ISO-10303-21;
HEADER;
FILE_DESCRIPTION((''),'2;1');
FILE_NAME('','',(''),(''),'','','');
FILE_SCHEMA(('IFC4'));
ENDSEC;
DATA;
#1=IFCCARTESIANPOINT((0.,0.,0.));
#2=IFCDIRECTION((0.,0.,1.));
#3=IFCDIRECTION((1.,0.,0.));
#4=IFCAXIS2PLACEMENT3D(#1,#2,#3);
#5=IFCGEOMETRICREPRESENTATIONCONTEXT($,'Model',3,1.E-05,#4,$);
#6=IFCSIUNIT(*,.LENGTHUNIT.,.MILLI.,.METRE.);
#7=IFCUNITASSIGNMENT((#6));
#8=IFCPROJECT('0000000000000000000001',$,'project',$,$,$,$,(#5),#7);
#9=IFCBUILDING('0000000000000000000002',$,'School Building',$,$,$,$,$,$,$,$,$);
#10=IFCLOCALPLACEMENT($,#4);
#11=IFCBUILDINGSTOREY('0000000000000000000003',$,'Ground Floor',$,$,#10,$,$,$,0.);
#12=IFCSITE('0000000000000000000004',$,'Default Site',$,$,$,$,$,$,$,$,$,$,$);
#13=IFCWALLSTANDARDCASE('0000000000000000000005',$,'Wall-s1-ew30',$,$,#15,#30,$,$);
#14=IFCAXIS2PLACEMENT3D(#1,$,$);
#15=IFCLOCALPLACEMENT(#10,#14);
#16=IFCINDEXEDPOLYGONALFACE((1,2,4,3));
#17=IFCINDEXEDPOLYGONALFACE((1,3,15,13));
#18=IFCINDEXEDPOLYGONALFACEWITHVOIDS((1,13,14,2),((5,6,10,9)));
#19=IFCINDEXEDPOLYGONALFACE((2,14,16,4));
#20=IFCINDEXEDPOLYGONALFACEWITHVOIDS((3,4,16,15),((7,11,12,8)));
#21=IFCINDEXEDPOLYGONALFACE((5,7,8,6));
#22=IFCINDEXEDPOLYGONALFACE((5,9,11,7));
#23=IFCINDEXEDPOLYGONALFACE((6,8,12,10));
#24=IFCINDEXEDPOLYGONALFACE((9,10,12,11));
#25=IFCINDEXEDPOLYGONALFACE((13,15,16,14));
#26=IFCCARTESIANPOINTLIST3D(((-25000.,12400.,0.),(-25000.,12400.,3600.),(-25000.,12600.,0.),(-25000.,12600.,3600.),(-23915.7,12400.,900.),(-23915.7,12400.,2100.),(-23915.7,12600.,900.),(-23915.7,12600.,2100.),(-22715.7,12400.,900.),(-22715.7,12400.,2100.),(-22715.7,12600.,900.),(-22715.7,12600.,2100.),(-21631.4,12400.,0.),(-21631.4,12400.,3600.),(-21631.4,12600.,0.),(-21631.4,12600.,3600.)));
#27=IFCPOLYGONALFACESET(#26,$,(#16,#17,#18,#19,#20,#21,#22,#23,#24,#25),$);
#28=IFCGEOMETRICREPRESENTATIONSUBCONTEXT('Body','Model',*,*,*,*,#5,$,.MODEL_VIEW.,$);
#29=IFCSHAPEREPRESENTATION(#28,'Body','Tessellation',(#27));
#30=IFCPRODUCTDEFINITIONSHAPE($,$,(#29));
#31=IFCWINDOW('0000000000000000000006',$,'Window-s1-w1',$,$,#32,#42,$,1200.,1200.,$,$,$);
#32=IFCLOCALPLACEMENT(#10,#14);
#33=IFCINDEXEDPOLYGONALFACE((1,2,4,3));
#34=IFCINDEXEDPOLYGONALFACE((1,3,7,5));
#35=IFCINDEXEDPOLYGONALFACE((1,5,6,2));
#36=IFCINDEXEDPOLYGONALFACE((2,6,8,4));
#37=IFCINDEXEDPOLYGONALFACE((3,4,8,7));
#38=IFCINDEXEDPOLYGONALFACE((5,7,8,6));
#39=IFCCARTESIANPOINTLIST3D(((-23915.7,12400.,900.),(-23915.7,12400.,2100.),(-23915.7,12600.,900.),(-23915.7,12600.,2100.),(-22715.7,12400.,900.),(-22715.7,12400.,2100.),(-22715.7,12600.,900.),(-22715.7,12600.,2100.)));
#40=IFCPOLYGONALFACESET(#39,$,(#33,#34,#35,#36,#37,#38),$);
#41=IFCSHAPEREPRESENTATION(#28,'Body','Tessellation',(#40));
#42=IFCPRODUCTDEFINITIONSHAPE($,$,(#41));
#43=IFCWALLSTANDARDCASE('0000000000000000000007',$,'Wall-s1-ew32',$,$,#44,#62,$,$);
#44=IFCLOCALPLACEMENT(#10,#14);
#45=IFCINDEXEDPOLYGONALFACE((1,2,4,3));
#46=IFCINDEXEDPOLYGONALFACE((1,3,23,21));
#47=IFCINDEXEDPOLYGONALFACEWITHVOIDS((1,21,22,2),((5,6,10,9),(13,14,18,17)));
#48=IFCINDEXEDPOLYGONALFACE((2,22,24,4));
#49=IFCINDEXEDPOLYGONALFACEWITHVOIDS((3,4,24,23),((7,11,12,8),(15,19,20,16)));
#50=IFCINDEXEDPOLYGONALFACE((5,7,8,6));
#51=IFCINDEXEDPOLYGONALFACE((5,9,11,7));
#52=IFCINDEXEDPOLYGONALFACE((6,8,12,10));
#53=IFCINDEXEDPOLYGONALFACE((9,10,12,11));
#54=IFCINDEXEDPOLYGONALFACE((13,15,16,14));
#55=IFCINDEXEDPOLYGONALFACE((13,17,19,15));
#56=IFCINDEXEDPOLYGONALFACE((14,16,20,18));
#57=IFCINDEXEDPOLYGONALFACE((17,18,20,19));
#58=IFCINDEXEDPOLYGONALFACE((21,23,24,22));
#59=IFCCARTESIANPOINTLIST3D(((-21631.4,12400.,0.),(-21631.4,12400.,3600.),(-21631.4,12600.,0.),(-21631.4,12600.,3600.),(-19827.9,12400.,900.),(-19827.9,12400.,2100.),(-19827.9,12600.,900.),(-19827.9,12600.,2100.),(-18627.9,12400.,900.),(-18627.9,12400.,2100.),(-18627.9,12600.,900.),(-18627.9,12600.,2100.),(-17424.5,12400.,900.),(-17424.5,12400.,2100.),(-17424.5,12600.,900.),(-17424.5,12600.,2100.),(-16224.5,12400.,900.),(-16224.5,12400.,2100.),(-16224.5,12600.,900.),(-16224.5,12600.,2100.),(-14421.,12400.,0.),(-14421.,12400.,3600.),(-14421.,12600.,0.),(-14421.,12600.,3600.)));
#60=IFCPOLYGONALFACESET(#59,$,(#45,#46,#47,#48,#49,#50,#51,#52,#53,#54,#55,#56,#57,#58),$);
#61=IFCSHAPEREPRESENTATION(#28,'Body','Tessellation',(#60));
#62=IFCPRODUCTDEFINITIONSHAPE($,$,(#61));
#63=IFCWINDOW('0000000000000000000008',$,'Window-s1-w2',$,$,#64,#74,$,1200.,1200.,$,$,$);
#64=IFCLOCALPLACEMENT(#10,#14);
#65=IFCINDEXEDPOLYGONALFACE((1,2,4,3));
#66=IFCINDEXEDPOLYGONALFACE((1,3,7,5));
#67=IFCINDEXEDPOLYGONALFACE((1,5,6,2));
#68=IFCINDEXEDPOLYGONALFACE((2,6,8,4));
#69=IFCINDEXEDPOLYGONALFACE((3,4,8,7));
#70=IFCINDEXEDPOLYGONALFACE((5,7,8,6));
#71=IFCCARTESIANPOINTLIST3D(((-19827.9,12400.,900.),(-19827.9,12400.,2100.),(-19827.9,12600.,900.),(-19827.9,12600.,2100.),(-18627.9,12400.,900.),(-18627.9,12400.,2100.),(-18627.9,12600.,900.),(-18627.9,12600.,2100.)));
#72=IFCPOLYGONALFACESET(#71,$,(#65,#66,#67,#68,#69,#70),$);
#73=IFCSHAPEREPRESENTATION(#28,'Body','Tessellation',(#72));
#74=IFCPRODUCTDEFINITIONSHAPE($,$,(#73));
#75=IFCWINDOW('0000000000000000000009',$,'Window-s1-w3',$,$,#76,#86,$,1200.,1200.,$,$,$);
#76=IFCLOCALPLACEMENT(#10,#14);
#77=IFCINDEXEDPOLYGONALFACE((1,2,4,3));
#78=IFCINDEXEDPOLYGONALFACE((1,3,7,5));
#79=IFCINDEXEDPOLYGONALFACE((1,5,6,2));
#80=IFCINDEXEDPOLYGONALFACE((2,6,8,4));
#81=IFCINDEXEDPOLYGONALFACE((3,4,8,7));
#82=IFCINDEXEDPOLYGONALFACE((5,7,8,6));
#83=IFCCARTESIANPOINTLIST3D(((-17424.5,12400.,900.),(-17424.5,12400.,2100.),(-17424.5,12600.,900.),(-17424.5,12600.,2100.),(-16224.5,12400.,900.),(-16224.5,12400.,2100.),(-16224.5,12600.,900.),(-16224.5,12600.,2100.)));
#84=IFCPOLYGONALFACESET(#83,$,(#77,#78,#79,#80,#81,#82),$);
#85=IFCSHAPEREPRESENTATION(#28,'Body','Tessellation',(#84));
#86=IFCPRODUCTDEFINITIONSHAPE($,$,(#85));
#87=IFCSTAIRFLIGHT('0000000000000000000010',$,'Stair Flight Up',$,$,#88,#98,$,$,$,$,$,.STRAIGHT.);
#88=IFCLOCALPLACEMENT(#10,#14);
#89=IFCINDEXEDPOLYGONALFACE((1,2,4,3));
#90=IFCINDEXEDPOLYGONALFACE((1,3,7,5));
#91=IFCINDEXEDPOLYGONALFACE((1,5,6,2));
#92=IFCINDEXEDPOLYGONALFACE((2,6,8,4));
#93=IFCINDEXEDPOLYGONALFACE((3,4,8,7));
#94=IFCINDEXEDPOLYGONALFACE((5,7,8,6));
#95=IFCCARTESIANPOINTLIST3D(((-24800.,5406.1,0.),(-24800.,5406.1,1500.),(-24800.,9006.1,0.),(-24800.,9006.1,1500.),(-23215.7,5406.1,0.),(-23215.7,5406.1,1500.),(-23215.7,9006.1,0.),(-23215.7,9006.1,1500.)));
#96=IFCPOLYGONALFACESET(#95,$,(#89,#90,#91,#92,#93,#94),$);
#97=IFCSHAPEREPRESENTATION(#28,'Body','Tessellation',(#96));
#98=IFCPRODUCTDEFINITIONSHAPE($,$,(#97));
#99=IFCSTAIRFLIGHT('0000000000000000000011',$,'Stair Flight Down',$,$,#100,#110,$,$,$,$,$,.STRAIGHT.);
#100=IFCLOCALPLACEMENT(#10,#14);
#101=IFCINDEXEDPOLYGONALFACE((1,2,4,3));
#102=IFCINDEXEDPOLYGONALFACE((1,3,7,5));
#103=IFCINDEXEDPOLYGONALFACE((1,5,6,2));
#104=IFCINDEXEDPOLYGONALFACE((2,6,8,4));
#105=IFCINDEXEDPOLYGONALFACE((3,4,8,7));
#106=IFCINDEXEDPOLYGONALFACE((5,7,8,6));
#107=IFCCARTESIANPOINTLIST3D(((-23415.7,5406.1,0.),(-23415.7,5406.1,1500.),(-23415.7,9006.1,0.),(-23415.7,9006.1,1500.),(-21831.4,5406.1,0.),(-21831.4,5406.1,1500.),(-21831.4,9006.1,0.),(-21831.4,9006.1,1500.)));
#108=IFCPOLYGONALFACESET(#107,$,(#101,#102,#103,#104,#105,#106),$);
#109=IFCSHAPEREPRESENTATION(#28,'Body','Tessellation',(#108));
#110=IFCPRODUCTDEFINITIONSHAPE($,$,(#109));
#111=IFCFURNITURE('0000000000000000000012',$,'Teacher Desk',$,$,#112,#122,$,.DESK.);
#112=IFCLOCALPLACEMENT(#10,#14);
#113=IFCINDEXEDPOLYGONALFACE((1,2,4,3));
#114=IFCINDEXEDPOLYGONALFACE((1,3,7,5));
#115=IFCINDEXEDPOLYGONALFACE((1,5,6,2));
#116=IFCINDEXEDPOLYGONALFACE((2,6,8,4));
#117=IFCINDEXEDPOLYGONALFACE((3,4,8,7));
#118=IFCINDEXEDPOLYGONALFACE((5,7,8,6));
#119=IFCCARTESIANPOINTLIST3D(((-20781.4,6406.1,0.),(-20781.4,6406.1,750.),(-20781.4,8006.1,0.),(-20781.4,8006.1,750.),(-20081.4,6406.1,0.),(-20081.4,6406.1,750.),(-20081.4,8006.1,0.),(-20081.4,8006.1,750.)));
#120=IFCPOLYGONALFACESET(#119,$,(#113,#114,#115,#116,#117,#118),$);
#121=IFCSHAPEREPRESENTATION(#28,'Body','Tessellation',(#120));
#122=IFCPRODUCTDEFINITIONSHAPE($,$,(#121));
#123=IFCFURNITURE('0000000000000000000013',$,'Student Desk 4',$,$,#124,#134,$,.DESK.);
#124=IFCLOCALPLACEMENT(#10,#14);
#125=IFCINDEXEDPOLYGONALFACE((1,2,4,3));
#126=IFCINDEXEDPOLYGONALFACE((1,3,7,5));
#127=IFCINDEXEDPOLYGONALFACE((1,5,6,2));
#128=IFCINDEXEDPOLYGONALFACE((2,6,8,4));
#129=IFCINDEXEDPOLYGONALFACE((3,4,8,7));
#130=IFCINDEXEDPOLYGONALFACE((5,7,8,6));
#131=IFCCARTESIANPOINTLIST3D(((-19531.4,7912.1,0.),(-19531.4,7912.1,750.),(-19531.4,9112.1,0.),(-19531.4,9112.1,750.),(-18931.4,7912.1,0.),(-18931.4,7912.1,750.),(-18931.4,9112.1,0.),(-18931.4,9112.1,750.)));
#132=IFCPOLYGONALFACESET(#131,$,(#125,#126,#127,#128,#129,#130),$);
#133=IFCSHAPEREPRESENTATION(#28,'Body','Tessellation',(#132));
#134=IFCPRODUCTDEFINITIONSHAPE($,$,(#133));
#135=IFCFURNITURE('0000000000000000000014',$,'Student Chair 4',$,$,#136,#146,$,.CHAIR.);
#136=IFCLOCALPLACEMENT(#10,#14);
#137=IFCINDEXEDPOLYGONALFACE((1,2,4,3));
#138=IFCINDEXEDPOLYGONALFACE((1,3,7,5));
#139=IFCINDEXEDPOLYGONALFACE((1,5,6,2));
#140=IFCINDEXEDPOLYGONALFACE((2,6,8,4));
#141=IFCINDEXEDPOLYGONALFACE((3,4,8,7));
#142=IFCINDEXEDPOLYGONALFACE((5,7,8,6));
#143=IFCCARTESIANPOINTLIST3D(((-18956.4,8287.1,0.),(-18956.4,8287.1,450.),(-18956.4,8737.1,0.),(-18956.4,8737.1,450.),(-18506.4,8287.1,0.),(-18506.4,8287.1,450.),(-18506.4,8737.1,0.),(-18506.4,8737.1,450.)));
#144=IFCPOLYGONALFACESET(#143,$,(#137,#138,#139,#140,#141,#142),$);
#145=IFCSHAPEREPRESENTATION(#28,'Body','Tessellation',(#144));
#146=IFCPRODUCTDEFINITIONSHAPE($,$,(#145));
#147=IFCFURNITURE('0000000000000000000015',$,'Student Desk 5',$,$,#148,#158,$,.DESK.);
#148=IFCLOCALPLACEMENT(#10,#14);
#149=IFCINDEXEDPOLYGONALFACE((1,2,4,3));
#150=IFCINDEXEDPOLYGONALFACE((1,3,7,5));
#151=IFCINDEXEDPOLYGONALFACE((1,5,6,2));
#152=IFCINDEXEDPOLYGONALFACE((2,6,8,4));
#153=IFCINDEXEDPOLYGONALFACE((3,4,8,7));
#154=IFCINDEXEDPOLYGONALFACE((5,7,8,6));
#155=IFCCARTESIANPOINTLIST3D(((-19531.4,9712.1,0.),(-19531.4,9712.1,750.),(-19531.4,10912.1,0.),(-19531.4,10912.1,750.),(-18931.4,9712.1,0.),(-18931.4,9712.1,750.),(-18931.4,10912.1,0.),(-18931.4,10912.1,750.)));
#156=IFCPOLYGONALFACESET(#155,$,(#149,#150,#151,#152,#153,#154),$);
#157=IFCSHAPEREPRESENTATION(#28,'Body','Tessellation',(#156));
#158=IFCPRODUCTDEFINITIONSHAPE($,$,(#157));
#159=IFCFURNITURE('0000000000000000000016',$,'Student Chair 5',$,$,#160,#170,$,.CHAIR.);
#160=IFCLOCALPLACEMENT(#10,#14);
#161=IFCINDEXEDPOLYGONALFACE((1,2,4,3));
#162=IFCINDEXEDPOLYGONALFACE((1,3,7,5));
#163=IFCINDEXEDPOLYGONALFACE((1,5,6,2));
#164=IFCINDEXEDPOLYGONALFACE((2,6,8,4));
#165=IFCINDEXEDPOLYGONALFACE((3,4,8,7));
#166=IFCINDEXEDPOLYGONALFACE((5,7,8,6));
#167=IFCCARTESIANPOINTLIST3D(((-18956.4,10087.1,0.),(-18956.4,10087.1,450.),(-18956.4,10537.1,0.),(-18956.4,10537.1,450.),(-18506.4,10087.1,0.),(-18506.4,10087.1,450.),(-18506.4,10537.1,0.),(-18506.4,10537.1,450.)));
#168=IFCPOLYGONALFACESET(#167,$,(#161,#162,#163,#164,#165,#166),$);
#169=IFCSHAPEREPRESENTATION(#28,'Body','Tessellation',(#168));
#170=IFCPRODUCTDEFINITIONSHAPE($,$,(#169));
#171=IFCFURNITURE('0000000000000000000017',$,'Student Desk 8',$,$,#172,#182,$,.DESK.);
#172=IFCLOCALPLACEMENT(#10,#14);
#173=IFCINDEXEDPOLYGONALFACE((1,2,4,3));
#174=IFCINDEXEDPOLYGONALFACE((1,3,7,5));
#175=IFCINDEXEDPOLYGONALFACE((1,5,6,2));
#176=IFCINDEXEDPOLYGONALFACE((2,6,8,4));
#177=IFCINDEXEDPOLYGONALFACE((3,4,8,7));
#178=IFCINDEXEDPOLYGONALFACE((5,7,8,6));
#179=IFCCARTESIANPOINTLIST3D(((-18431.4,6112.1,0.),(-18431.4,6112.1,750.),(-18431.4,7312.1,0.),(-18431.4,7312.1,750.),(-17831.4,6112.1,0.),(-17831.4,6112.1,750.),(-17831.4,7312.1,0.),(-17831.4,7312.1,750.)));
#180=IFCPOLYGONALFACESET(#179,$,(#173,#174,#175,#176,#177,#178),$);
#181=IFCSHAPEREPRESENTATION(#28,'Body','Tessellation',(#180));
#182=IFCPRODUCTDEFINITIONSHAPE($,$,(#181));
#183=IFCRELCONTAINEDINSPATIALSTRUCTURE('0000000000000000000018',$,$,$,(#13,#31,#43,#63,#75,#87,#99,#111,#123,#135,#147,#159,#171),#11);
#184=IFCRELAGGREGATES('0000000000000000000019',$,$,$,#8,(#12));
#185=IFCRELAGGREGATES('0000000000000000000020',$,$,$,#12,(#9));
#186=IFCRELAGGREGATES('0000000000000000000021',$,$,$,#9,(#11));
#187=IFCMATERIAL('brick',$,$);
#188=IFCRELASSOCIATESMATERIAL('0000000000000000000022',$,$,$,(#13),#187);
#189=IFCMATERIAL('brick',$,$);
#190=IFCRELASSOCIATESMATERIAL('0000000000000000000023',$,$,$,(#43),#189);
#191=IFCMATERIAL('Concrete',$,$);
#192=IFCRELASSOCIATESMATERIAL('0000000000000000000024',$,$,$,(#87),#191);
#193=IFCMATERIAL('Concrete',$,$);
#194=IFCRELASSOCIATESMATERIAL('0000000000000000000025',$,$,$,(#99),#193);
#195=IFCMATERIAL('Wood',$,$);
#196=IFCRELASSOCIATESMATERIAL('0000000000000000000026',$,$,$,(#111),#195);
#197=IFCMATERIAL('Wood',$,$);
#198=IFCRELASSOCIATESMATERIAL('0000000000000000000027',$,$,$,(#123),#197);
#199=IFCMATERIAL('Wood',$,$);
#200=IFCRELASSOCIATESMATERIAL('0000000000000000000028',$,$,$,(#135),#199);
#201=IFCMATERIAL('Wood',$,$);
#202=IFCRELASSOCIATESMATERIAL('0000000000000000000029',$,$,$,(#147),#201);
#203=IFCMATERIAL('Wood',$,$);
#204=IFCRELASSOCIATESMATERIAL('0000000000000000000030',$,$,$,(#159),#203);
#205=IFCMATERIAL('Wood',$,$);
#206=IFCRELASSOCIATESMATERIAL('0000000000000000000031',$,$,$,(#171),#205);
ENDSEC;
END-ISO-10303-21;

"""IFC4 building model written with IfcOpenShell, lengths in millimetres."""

from ifc_helpers import new_model, si_unit, frame, frame_2d, origin_with_axes, origin_2d, place, context, subcontext, project, spatial, rectangle, extrude, material, element, fill, save


model = new_model("IFC4")

# Units and contexts
model_context = context("Model", 3, precision=1e-05, world=origin_with_axes())
body_context = subcontext(model_context, "Body", "Model", "MODEL_VIEW")
ifc_project = project(units=[si_unit("LENGTHUNIT", "METRE", prefix="MILLI")], contexts=[model_context])

# Site, building, storey
site = spatial("IfcSite", under=ifc_project, Name="Default Site")
building = spatial("IfcBuilding", under=site, Name="School Building")
storey_placement = place(None, origin_with_axes())
storey = spatial("IfcBuildingStorey", under=building, at=storey_placement, Name="Ground Floor", Elevation=0.0)

# Wall, opening, window
ifc_material_1 = material(Name="brick")
wall_1_placement = place(storey_placement, frame((-25000.0, 12500.0, 0.0), z_axis=(0.0, 0.0, 1.0), x_axis=(1.0, 0.0, 0.0)))
wall_1 = element("IfcWallStandardCase", 1, at=wall_1_placement, inside=storey, material=ifc_material_1, Name="Wall-s1-ew30", context=body_context, shape_type="SweptSolid", body=[
    extrude(rectangle(XDim=3368.6, YDim=200.0, at=frame_2d((1684.3, 0.0))), origin_with_axes(), (0.0, 0.0, 1.0), 3600.0),
])
opening_1_placement = place(wall_1_placement, frame((1084.3, 0.0, 900.0), z_axis=(0.0, 0.0, 1.0), x_axis=(1.0, 0.0, 0.0)))
opening_1 = element("IfcOpeningElement", 2, at=opening_1_placement, cuts=wall_1, context=body_context, shape_type="SweptSolid", body=[
    extrude(rectangle(XDim=1200.0, YDim=400.0, at=frame_2d((600.0, 0.0))), origin_with_axes(), (0.0, 0.0, 1.0), 1200.0),
])
window_1_placement = place(storey_placement, frame((-23915.7, 12500.0, 900.0), z_axis=(0.0, 0.0, 1.0), x_axis=(1.0, 0.0, 0.0)))
window_1 = element("IfcWindow", 3, at=window_1_placement, inside=storey, Name="Window-s1-w1", OverallHeight=1200.0, OverallWidth=1200.0, context=body_context, shape_type="SweptSolid", body=[
    extrude(rectangle(XDim=1200.0, YDim=200.0, at=frame_2d((600.0, 0.0))), origin_with_axes(), (0.0, 0.0, 1.0), 1200.0),
])
fill(opening_1, window_1)

# Wall, openings, windows
ifc_material_2 = material(Name="brick")
wall_2_placement = place(storey_placement, frame((-21631.4, 12500.0, 0.0), z_axis=(0.0, 0.0, 1.0), x_axis=(1.0, 0.0, 0.0)))
wall_2 = element("IfcWallStandardCase", 4, at=wall_2_placement, inside=storey, material=ifc_material_2, Name="Wall-s1-ew32", context=body_context, shape_type="SweptSolid", body=[
    extrude(rectangle(XDim=7210.5, YDim=200.0, at=frame_2d((3605.2, 0.0))), origin_with_axes(), (0.0, 0.0, 1.0), 3600.0),
])
opening_2_placement = place(wall_2_placement, frame((1803.5, 0.0, 900.0), z_axis=(0.0, 0.0, 1.0), x_axis=(1.0, 0.0, 0.0)))
opening_2 = element("IfcOpeningElement", 5, at=opening_2_placement, cuts=wall_2, context=body_context, shape_type="SweptSolid", body=[
    extrude(rectangle(XDim=1200.0, YDim=400.0, at=frame_2d((600.0, 0.0))), origin_with_axes(), (0.0, 0.0, 1.0), 1200.0),
])
opening_3_placement = place(wall_2_placement, frame((4207.0, 0.0, 900.0), z_axis=(0.0, 0.0, 1.0), x_axis=(1.0, 0.0, 0.0)))
opening_3 = element("IfcOpeningElement", 6, at=opening_3_placement, cuts=wall_2, context=body_context, shape_type="SweptSolid", body=[
    extrude(rectangle(XDim=1200.0, YDim=400.0, at=frame_2d((600.0, 0.0))), origin_with_axes(), (0.0, 0.0, 1.0), 1200.0),
])
window_2_placement = place(storey_placement, frame((-19827.9, 12500.0, 900.0), z_axis=(0.0, 0.0, 1.0), x_axis=(1.0, 0.0, 0.0)))
window_2 = element("IfcWindow", 7, at=window_2_placement, inside=storey, Name="Window-s1-w2", OverallHeight=1200.0, OverallWidth=1200.0, context=body_context, shape_type="SweptSolid", body=[
    extrude(rectangle(XDim=1200.0, YDim=200.0, at=frame_2d((600.0, 0.0))), origin_with_axes(), (0.0, 0.0, 1.0), 1200.0),
])
fill(opening_2, window_2)
window_3_placement = place(storey_placement, frame((-17424.5, 12500.0, 900.0), z_axis=(0.0, 0.0, 1.0), x_axis=(1.0, 0.0, 0.0)))
window_3 = element("IfcWindow", 8, at=window_3_placement, inside=storey, Name="Window-s1-w3", OverallHeight=1200.0, OverallWidth=1200.0, context=body_context, shape_type="SweptSolid", body=[
    extrude(rectangle(XDim=1200.0, YDim=200.0, at=frame_2d((600.0, 0.0))), origin_with_axes(), (0.0, 0.0, 1.0), 1200.0),
])
fill(opening_3, window_3)

# Stair flights
ifc_material_3 = material(Name="Concrete")
stair_flight_1_placement = place(storey_placement, frame((-24007.9, 7206.1, 0.0), z_axis=(0.0, 0.0, 1.0), x_axis=(1.0, 0.0, 0.0)))
element("IfcStairFlight", 9, at=stair_flight_1_placement, inside=storey, material=ifc_material_3, Name="Stair Flight Up", PredefinedType="STRAIGHT", context=body_context, shape_type="SweptSolid", body=[
    extrude(rectangle(XDim=1584.3, YDim=3600.0, at=origin_2d()), origin_with_axes(), (0.0, 0.0, 1.0), 1500.0),
])
ifc_material_4 = material(Name="Concrete")
stair_flight_2_placement = place(storey_placement, frame((-22623.6, 7206.1, 0.0), z_axis=(0.0, 0.0, 1.0), x_axis=(1.0, 0.0, 0.0)))
element("IfcStairFlight", 10, at=stair_flight_2_placement, inside=storey, material=ifc_material_4, Name="Stair Flight Down", PredefinedType="STRAIGHT", context=body_context, shape_type="SweptSolid", body=[
    extrude(rectangle(XDim=1584.3, YDim=3600.0, at=origin_2d()), origin_with_axes(), (0.0, 0.0, 1.0), 1500.0),
])

# Furniture
ifc_material_5 = material(Name="Wood")
furniture_1_placement = place(storey_placement, frame((-20431.4, 7206.1, 0.0), z_axis=(0.0, 0.0, 1.0), x_axis=(0.0, 1.0, 0.0)))
element("IfcFurniture", 11, at=furniture_1_placement, inside=storey, material=ifc_material_5, Name="Teacher Desk", PredefinedType="DESK", context=body_context, shape_type="SweptSolid", body=[
    extrude(rectangle(XDim=1600.0, YDim=700.0, at=origin_2d()), origin_with_axes(), (0.0, 0.0, 1.0), 750.0),
])
ifc_material_6 = material(Name="Wood")
furniture_2_placement = place(storey_placement, frame((-19231.4, 8512.1, 0.0), z_axis=(0.0, 0.0, 1.0), x_axis=(0.0, 1.0, 0.0)))
element("IfcFurniture", 12, at=furniture_2_placement, inside=storey, material=ifc_material_6, Name="Student Desk 4", PredefinedType="DESK", context=body_context, shape_type="SweptSolid", body=[
    extrude(rectangle(XDim=1200.0, YDim=600.0, at=origin_2d()), origin_with_axes(), (0.0, 0.0, 1.0), 750.0),
])
ifc_material_7 = material(Name="Wood")
furniture_3_placement = place(storey_placement, frame((-18731.4, 8512.1, 0.0), z_axis=(0.0, 0.0, 1.0), x_axis=(1.0, 0.0, 0.0)))
element("IfcFurniture", 13, at=furniture_3_placement, inside=storey, material=ifc_material_7, Name="Student Chair 4", PredefinedType="CHAIR", context=body_context, shape_type="SweptSolid", body=[
    extrude(rectangle(XDim=450.0, YDim=450.0, at=origin_2d()), origin_with_axes(), (0.0, 0.0, 1.0), 450.0),
])
ifc_material_8 = material(Name="Wood")
furniture_4_placement = place(storey_placement, frame((-19231.4, 10312.1, 0.0), z_axis=(0.0, 0.0, 1.0), x_axis=(0.0, 1.0, 0.0)))
element("IfcFurniture", 14, at=furniture_4_placement, inside=storey, material=ifc_material_8, Name="Student Desk 5", PredefinedType="DESK", context=body_context, shape_type="SweptSolid", body=[
    extrude(rectangle(XDim=1200.0, YDim=600.0, at=origin_2d()), origin_with_axes(), (0.0, 0.0, 1.0), 750.0),
])
ifc_material_9 = material(Name="Wood")
furniture_5_placement = place(storey_placement, frame((-18731.4, 10312.1, 0.0), z_axis=(0.0, 0.0, 1.0), x_axis=(1.0, 0.0, 0.0)))
element("IfcFurniture", 15, at=furniture_5_placement, inside=storey, material=ifc_material_9, Name="Student Chair 5", PredefinedType="CHAIR", context=body_context, shape_type="SweptSolid", body=[
    extrude(rectangle(XDim=450.0, YDim=450.0, at=origin_2d()), origin_with_axes(), (0.0, 0.0, 1.0), 450.0),
])
ifc_material_10 = material(Name="Wood")
furniture_6_placement = place(storey_placement, frame((-18131.4, 6712.1, 0.0), z_axis=(0.0, 0.0, 1.0), x_axis=(0.0, 1.0, 0.0)))
element("IfcFurniture", 16, at=furniture_6_placement, inside=storey, material=ifc_material_10, Name="Student Desk 8", PredefinedType="DESK", context=body_context, shape_type="SweptSolid", body=[
    extrude(rectangle(XDim=1200.0, YDim=600.0, at=origin_2d()), origin_with_axes(), (0.0, 0.0, 1.0), 750.0),
])

save(model, "model.ifc")
